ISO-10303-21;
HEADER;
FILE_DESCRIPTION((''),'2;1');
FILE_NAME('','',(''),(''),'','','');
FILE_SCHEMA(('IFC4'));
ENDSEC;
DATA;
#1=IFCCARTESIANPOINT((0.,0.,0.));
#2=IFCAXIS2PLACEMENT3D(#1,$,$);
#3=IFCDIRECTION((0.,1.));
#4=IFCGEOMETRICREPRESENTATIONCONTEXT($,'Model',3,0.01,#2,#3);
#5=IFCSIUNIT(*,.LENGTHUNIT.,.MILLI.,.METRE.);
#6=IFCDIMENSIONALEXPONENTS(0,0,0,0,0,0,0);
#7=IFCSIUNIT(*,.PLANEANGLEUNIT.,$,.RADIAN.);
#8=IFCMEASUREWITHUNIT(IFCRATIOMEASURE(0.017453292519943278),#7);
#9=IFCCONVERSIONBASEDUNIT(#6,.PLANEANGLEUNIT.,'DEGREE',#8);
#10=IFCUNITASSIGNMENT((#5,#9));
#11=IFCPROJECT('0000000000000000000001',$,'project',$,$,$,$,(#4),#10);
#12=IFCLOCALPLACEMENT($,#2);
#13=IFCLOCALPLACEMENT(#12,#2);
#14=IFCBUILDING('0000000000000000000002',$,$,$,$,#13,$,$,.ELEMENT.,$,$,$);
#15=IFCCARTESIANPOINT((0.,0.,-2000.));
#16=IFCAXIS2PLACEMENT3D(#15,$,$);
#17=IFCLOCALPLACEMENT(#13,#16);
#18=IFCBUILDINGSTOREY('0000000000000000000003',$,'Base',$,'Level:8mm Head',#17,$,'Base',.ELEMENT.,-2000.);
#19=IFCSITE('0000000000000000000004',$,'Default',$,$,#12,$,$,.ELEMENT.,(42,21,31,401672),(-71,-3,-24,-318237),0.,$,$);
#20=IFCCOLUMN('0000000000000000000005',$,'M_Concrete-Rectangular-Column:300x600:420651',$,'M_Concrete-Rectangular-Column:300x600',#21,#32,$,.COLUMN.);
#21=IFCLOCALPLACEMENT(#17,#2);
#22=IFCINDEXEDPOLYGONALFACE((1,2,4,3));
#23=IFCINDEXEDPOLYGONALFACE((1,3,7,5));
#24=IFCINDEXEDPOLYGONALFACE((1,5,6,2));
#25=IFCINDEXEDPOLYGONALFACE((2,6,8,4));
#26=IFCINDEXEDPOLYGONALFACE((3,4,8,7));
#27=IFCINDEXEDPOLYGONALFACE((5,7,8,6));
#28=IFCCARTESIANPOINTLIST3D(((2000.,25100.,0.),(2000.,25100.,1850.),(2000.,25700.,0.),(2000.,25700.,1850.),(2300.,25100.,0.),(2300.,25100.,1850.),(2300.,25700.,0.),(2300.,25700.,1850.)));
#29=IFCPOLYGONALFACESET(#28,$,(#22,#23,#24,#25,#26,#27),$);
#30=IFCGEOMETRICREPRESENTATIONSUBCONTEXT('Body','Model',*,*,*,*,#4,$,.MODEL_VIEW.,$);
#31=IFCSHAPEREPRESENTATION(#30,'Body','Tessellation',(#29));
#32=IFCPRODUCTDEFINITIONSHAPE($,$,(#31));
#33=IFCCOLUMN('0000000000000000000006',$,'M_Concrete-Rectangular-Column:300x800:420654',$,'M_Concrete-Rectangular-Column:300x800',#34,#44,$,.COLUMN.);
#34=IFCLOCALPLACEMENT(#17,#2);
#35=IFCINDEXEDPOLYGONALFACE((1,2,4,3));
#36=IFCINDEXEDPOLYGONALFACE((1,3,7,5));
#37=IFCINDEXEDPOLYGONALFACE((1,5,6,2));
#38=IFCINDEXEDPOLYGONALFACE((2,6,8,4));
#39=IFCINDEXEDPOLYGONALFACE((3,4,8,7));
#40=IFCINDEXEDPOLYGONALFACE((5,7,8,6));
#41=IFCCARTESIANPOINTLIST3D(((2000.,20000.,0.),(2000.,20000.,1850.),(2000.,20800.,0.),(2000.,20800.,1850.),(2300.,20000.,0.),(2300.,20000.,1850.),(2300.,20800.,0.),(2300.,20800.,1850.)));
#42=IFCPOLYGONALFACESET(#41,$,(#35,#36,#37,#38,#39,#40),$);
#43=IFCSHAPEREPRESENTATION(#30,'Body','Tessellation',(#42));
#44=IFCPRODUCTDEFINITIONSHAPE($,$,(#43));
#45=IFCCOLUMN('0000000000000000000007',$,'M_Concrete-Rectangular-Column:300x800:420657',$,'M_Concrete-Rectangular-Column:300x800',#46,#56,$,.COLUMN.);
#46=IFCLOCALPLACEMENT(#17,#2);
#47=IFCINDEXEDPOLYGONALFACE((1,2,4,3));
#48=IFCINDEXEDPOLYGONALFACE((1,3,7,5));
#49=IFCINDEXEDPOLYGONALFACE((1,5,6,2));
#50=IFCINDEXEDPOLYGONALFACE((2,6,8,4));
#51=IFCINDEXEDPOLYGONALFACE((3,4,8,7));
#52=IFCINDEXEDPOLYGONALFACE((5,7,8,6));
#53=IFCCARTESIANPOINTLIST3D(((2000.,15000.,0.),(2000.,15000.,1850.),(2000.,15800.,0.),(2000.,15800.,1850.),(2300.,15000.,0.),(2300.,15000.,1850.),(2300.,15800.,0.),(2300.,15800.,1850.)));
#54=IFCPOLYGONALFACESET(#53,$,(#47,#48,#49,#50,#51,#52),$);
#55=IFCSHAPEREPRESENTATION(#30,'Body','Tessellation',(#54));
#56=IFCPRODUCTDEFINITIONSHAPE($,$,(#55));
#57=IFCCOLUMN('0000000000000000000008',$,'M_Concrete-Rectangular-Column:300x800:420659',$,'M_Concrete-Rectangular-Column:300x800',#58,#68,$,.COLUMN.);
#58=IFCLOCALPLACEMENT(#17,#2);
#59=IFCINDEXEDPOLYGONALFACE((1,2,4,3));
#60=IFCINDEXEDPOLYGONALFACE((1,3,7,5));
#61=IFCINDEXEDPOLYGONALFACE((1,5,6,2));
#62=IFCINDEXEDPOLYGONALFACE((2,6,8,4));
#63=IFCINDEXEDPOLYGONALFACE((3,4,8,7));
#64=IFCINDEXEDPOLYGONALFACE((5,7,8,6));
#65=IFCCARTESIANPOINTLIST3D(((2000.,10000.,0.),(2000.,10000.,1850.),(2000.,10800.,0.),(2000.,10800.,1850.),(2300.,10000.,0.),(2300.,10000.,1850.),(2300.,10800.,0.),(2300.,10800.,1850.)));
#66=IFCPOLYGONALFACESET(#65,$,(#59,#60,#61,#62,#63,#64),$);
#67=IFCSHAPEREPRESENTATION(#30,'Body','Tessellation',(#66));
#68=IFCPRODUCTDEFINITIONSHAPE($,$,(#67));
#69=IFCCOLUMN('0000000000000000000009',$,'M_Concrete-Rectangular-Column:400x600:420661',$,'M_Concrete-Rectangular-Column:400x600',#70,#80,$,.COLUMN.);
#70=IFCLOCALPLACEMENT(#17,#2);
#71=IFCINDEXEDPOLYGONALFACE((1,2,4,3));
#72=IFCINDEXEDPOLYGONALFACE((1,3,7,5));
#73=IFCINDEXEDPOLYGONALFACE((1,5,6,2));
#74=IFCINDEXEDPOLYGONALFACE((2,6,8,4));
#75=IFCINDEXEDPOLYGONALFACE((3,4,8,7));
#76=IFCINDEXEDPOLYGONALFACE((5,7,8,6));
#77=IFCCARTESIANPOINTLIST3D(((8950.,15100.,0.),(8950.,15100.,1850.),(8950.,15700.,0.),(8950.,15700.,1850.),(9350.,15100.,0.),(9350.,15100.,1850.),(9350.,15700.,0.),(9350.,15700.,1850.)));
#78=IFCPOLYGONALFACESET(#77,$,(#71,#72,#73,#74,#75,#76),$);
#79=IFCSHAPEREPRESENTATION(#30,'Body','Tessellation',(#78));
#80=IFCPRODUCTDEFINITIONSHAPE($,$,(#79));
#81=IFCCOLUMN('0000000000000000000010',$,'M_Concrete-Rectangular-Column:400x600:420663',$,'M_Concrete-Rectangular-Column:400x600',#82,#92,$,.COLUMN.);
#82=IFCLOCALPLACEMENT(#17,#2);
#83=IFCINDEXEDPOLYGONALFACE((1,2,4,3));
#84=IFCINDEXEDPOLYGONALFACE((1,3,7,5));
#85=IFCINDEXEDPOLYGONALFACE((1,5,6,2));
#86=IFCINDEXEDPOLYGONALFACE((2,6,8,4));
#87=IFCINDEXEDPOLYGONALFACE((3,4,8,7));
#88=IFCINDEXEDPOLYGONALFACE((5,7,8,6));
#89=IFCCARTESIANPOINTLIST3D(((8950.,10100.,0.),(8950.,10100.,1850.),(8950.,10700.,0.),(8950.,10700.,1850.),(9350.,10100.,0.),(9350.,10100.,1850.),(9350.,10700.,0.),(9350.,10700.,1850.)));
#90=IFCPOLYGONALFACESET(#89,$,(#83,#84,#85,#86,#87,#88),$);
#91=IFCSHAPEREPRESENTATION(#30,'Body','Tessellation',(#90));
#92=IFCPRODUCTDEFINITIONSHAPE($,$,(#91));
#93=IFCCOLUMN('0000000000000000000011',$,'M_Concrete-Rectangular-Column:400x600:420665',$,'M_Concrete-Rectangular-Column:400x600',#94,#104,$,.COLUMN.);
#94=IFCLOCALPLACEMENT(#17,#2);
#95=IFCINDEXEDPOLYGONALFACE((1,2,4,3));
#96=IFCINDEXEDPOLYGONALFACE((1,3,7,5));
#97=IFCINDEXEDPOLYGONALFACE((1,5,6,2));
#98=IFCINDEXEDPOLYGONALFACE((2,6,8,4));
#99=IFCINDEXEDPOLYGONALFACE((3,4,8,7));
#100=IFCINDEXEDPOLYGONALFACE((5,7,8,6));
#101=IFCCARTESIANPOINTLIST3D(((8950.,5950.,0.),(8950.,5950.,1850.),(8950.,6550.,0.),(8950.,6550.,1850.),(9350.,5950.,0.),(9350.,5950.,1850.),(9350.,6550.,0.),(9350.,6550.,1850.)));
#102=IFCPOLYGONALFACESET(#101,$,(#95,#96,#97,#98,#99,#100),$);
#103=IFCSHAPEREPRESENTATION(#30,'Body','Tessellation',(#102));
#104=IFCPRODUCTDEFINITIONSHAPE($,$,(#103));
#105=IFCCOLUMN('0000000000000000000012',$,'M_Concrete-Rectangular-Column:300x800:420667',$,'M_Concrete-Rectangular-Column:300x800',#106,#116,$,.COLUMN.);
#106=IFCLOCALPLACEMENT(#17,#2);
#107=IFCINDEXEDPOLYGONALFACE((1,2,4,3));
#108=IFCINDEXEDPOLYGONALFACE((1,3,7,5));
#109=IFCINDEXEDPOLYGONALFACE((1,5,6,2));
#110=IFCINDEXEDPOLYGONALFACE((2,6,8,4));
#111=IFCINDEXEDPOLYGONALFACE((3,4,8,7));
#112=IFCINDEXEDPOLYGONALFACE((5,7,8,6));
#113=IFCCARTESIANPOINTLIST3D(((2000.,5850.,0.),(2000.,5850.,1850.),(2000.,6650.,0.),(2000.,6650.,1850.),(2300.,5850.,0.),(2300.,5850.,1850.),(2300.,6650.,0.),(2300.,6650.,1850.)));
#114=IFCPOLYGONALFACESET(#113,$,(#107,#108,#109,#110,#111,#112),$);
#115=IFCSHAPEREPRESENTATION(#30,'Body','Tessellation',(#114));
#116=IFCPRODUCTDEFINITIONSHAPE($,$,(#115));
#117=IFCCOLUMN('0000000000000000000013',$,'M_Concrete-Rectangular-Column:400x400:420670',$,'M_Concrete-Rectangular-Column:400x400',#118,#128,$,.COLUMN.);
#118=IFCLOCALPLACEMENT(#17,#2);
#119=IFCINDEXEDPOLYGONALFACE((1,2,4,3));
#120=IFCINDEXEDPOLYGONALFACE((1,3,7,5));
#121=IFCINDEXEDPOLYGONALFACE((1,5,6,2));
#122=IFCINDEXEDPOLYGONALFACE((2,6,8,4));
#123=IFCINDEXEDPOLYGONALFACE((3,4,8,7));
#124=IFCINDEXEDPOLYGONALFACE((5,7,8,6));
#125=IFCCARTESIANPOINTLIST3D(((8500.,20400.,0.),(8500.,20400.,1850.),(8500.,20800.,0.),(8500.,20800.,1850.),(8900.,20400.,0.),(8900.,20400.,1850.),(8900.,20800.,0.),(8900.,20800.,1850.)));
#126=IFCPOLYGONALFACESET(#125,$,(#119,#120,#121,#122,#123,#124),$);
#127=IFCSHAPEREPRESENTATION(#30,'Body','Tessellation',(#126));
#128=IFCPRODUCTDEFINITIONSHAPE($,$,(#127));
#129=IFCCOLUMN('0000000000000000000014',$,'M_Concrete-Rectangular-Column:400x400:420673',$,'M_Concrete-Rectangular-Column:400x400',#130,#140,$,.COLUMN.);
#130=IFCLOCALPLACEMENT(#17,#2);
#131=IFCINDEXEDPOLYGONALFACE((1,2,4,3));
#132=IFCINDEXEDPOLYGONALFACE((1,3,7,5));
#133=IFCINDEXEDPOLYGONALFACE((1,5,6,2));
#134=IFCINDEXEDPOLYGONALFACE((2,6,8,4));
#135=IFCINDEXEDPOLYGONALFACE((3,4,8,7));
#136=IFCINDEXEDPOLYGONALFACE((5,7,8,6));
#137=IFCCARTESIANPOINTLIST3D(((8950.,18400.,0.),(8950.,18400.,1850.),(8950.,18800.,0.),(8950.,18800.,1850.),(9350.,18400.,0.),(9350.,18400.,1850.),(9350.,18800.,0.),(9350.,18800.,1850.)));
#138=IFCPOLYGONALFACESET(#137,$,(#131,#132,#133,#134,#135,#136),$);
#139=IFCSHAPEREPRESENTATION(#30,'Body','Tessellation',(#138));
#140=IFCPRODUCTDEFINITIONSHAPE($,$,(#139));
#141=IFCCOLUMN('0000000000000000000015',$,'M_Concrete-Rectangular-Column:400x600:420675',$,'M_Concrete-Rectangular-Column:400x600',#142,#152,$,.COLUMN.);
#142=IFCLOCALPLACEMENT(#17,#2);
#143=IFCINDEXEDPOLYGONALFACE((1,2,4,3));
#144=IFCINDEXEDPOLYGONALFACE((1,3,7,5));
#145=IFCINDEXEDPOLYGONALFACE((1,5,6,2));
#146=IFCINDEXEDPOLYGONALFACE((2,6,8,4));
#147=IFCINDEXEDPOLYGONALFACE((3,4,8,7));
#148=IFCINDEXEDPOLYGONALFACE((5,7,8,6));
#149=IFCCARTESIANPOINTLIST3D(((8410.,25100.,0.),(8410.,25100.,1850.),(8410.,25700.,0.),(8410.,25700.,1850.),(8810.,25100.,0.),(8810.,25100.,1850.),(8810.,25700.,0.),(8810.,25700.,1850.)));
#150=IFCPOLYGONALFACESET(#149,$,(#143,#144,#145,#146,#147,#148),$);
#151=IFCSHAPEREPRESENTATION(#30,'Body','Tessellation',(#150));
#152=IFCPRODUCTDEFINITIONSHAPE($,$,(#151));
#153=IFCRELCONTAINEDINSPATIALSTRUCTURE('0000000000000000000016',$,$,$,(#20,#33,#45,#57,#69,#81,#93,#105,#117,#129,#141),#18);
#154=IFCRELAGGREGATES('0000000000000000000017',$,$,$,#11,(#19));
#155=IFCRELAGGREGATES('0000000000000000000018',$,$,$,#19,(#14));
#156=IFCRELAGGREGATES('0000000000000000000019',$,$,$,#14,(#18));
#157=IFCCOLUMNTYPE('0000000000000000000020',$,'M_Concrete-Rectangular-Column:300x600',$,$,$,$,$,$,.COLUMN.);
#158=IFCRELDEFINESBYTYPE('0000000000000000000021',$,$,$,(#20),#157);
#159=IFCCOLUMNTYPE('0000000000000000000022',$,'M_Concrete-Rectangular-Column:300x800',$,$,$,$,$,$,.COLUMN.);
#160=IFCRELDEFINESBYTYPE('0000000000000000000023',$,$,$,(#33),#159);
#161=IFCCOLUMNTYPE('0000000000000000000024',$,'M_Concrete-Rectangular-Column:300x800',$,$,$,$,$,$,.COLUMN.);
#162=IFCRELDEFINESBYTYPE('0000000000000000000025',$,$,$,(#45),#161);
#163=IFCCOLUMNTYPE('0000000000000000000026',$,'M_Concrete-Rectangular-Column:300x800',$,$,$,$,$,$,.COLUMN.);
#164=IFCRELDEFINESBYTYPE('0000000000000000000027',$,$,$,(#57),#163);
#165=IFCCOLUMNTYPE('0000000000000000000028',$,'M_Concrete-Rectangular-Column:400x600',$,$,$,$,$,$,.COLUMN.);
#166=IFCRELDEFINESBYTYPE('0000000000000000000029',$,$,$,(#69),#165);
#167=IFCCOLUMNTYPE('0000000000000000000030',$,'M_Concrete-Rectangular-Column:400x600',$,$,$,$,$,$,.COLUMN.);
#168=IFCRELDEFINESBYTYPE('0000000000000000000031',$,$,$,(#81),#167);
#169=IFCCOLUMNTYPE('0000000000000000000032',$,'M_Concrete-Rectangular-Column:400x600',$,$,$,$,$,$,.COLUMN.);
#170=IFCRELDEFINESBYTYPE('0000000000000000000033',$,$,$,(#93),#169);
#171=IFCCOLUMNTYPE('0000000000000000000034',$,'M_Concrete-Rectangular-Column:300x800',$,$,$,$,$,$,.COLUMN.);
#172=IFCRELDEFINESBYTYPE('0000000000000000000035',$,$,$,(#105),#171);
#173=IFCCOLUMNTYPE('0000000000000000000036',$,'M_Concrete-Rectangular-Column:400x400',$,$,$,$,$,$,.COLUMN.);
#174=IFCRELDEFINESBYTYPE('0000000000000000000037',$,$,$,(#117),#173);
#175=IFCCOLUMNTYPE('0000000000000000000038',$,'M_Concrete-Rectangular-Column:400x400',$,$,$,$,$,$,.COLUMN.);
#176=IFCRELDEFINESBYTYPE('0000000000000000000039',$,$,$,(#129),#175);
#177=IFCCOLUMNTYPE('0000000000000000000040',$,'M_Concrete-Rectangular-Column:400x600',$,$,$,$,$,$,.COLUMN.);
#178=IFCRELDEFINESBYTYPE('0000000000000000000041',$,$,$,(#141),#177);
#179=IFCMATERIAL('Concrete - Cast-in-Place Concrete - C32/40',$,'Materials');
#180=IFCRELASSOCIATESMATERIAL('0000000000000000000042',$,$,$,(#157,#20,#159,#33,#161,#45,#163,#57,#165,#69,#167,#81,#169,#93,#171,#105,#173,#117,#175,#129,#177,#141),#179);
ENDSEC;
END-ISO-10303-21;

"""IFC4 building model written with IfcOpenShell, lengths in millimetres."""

from ifc_helpers import new_model, entity, si_unit, converted_unit, direction, frame, origin, place, context, subcontext, project, spatial, indexed_curve, outline, extrude, source, transform, mapped, material, type_object, type_shapes, element, save


model = new_model("IFC4")

# Units and contexts
model_context = context("Model", 3, precision=0.01, world=origin(), true_north=direction((0.0, 1.0)))
body_context = subcontext(model_context, "Body", "Model", "MODEL_VIEW")
ifc_project = project(units=[si_unit("LENGTHUNIT", "METRE", prefix="MILLI"), converted_unit("PLANEANGLEUNIT", "DEGREE", entity("IfcRatioMeasure", 0.017453292519943278), si_unit("PLANEANGLEUNIT", "RADIAN"), dimensions=[0, 0, 0, 0, 0, 0, 0])], contexts=[model_context])

# Site, building, storey
site_placement = place(None, origin())
site = spatial("IfcSite", under=ifc_project, at=site_placement, Name="Default", CompositionType="ELEMENT", RefLatitude=(42, 21, 31, 401672), RefLongitude=(-71, -3, -24, -318237), RefElevation=0.0)
building_placement = place(site_placement, origin())
building = spatial("IfcBuilding", under=site, at=building_placement, CompositionType="ELEMENT")
storey_placement = place(building_placement, frame((0.0, 0.0, -2000.0)))
storey = spatial("IfcBuildingStorey", under=building, at=storey_placement, Name="Base", ObjectType="Level:8mm Head", LongName="Base", CompositionType="ELEMENT", Elevation=-2000.0)

# Columns
ifc_material = material(Name="Concrete - Cast-in-Place Concrete - C32/40", Category="Materials")
column_type_1 = type_object("IfcColumnType", Name="M_Concrete-Rectangular-Column:300x600", PredefinedType="COLUMN", material=ifc_material)
shared_shape_1 = source(origin(), body_context, "Body", "SweptSolid", [
    extrude(outline(indexed_curve([(-300.0, -150.0), (300.0, -150.0), (300.0, 150.0), (-300.0, 150.0), (-300.0, -150.0)], self_intersect=False)), frame((2150.0, 25400.0, -2000.0), z_axis=(0.0, 0.0, 1.0), x_axis=(0.0, -1.0, 0.0)), (0.0, 0.0, 1.0), 1850.0),
])
type_shapes(column_type_1, [shared_shape_1])
column_1_placement = place(storey_placement, frame((0.0, 0.0, 2000.0)))
element("IfcColumn", 1, at=column_1_placement, inside=storey, type_object=column_type_1, material=ifc_material, Name="M_Concrete-Rectangular-Column:300x600:420651", ObjectType="M_Concrete-Rectangular-Column:300x600", PredefinedType="COLUMN", context=body_context, shape_type="MappedRepresentation", body=[
    mapped(shared_shape_1, transform((0.0, 0.0, 0.0), scale=1.0)),
])
column_type_2 = type_object("IfcColumnType", Name="M_Concrete-Rectangular-Column:300x800", PredefinedType="COLUMN", material=ifc_material)
shared_shape_2 = source(origin(), body_context, "Body", "SweptSolid", [
    extrude(outline(indexed_curve([(-400.0, -150.0), (400.0, -150.0), (400.0, 150.0), (-400.0, 150.0), (-400.0, -150.0)], self_intersect=False)), frame((2150.0, 20400.0, -2000.0), z_axis=(0.0, 0.0, 1.0), x_axis=(0.0, -1.0, 0.0)), (0.0, 0.0, 1.0), 1850.0),
])
type_shapes(column_type_2, [shared_shape_2])
column_2_placement = place(storey_placement, frame((0.0, 0.0, 2000.0)))
element("IfcColumn", 2, at=column_2_placement, inside=storey, type_object=column_type_2, material=ifc_material, Name="M_Concrete-Rectangular-Column:300x800:420654", ObjectType="M_Concrete-Rectangular-Column:300x800", PredefinedType="COLUMN", context=body_context, shape_type="MappedRepresentation", body=[
    mapped(shared_shape_2, transform((0.0, 0.0, 0.0), scale=1.0)),
])
column_type_3 = type_object("IfcColumnType", Name="M_Concrete-Rectangular-Column:300x800", PredefinedType="COLUMN", material=ifc_material)
shared_shape_3 = source(origin(), body_context, "Body", "SweptSolid", [
    extrude(outline(indexed_curve([(-400.0, -150.0), (400.0, -150.0), (400.0, 150.0), (-400.0, 150.0), (-400.0, -150.0)], self_intersect=False)), frame((2150.0, 15400.0, -2000.0), z_axis=(0.0, 0.0, 1.0), x_axis=(0.0, -1.0, 0.0)), (0.0, 0.0, 1.0), 1850.0),
])
type_shapes(column_type_3, [shared_shape_3])
column_3_placement = place(storey_placement, frame((0.0, 0.0, 2000.0)))
element("IfcColumn", 3, at=column_3_placement, inside=storey, type_object=column_type_3, material=ifc_material, Name="M_Concrete-Rectangular-Column:300x800:420657", ObjectType="M_Concrete-Rectangular-Column:300x800", PredefinedType="COLUMN", context=body_context, shape_type="MappedRepresentation", body=[
    mapped(shared_shape_3, transform((0.0, 0.0, 0.0), scale=1.0)),
])
column_type_4 = type_object("IfcColumnType", Name="M_Concrete-Rectangular-Column:300x800", PredefinedType="COLUMN", material=ifc_material)
shared_shape_4 = source(origin(), body_context, "Body", "SweptSolid", [
    extrude(outline(indexed_curve([(-400.0, -150.0), (400.0, -150.0), (400.0, 150.0), (-400.0, 150.0), (-400.0, -150.0)], self_intersect=False)), frame((2150.0, 10400.0, -2000.0), z_axis=(0.0, 0.0, 1.0), x_axis=(0.0, -1.0, 0.0)), (0.0, 0.0, 1.0), 1850.0),
])
type_shapes(column_type_4, [shared_shape_4])
column_4_placement = place(storey_placement, frame((0.0, 0.0, 2000.0)))
element("IfcColumn", 4, at=column_4_placement, inside=storey, type_object=column_type_4, material=ifc_material, Name="M_Concrete-Rectangular-Column:300x800:420659", ObjectType="M_Concrete-Rectangular-Column:300x800", PredefinedType="COLUMN", context=body_context, shape_type="MappedRepresentation", body=[
    mapped(shared_shape_4, transform((0.0, 0.0, 0.0), scale=1.0)),
])
column_type_5 = type_object("IfcColumnType", Name="M_Concrete-Rectangular-Column:400x600", PredefinedType="COLUMN", material=ifc_material)
shared_shape_5 = source(origin(), body_context, "Body", "SweptSolid", [
    extrude(outline(indexed_curve([(-300.0, -200.0), (300.0, -200.0), (300.0, 200.0), (-300.0, 200.0), (-300.0, -200.0)], self_intersect=False)), frame((9150.0, 15400.0, -2000.0), z_axis=(0.0, 0.0, 1.0), x_axis=(0.0, -1.0, 0.0)), (0.0, 0.0, 1.0), 1850.0),
])
type_shapes(column_type_5, [shared_shape_5])
column_5_placement = place(storey_placement, frame((0.0, 0.0, 2000.0)))
element("IfcColumn", 5, at=column_5_placement, inside=storey, type_object=column_type_5, material=ifc_material, Name="M_Concrete-Rectangular-Column:400x600:420661", ObjectType="M_Concrete-Rectangular-Column:400x600", PredefinedType="COLUMN", context=body_context, shape_type="MappedRepresentation", body=[
    mapped(shared_shape_5, transform((0.0, 0.0, 0.0), scale=1.0)),
])
column_type_6 = type_object("IfcColumnType", Name="M_Concrete-Rectangular-Column:400x600", PredefinedType="COLUMN", material=ifc_material)
shared_shape_6 = source(origin(), body_context, "Body", "SweptSolid", [
    extrude(outline(indexed_curve([(-300.0, -200.0), (300.0, -200.0), (300.0, 200.0), (-300.0, 200.0), (-300.0, -200.0)], self_intersect=False)), frame((9150.0, 10400.0, -2000.0), z_axis=(0.0, 0.0, 1.0), x_axis=(0.0, -1.0, 0.0)), (0.0, 0.0, 1.0), 1850.0),
])
type_shapes(column_type_6, [shared_shape_6])
column_6_placement = place(storey_placement, frame((0.0, 0.0, 2000.0)))
element("IfcColumn", 6, at=column_6_placement, inside=storey, type_object=column_type_6, material=ifc_material, Name="M_Concrete-Rectangular-Column:400x600:420663", ObjectType="M_Concrete-Rectangular-Column:400x600", PredefinedType="COLUMN", context=body_context, shape_type="MappedRepresentation", body=[
    mapped(shared_shape_6, transform((0.0, 0.0, 0.0), scale=1.0)),
])
column_type_7 = type_object("IfcColumnType", Name="M_Concrete-Rectangular-Column:400x600", PredefinedType="COLUMN", material=ifc_material)
shared_shape_7 = source(origin(), body_context, "Body", "SweptSolid", [
    extrude(outline(indexed_curve([(-300.0, -200.0), (300.0, -200.0), (300.0, 200.0), (-300.0, 200.0), (-300.0, -200.0)], self_intersect=False)), frame((9150.0, 6250.0, -2000.0), z_axis=(0.0, 0.0, 1.0), x_axis=(0.0, -1.0, 0.0)), (0.0, 0.0, 1.0), 1850.0),
])
type_shapes(column_type_7, [shared_shape_7])
column_7_placement = place(storey_placement, frame((0.0, 0.0, 2000.0)))
element("IfcColumn", 7, at=column_7_placement, inside=storey, type_object=column_type_7, material=ifc_material, Name="M_Concrete-Rectangular-Column:400x600:420665", ObjectType="M_Concrete-Rectangular-Column:400x600", PredefinedType="COLUMN", context=body_context, shape_type="MappedRepresentation", body=[
    mapped(shared_shape_7, transform((0.0, 0.0, 0.0), scale=1.0)),
])
column_type_8 = type_object("IfcColumnType", Name="M_Concrete-Rectangular-Column:300x800", PredefinedType="COLUMN", material=ifc_material)
shared_shape_8 = source(origin(), body_context, "Body", "SweptSolid", [
    extrude(outline(indexed_curve([(-400.0, -150.0), (400.0, -150.0), (400.0, 150.0), (-400.0, 150.0), (-400.0, -150.0)], self_intersect=False)), frame((2150.0, 6250.0, -2000.0), z_axis=(0.0, 0.0, 1.0), x_axis=(0.0, -1.0, 0.0)), (0.0, 0.0, 1.0), 1850.0),
])
type_shapes(column_type_8, [shared_shape_8])
column_8_placement = place(storey_placement, frame((0.0, 0.0, 2000.0)))
element("IfcColumn", 8, at=column_8_placement, inside=storey, type_object=column_type_8, material=ifc_material, Name="M_Concrete-Rectangular-Column:300x800:420667", ObjectType="M_Concrete-Rectangular-Column:300x800", PredefinedType="COLUMN", context=body_context, shape_type="MappedRepresentation", body=[
    mapped(shared_shape_8, transform((0.0, 0.0, 0.0), scale=1.0)),
])
column_type_9 = type_object("IfcColumnType", Name="M_Concrete-Rectangular-Column:400x400", PredefinedType="COLUMN", material=ifc_material)
shared_shape_9 = source(origin(), body_context, "Body", "SweptSolid", [
    extrude(outline(indexed_curve([(-200.0, -200.0), (200.0, -200.0), (200.0, 200.0), (-200.0, 200.0), (-200.0, -200.0)], self_intersect=False)), frame((8700.0, 20600.0, -2000.0), z_axis=(0.0, 0.0, 1.0), x_axis=(0.0, -1.0, 0.0)), (0.0, 0.0, 1.0), 1850.0),
])
type_shapes(column_type_9, [shared_shape_9])
column_9_placement = place(storey_placement, frame((0.0, 0.0, 2000.0)))
element("IfcColumn", 9, at=column_9_placement, inside=storey, type_object=column_type_9, material=ifc_material, Name="M_Concrete-Rectangular-Column:400x400:420670", ObjectType="M_Concrete-Rectangular-Column:400x400", PredefinedType="COLUMN", context=body_context, shape_type="MappedRepresentation", body=[
    mapped(shared_shape_9, transform((0.0, 0.0, 0.0), scale=1.0)),
])
column_type_10 = type_object("IfcColumnType", Name="M_Concrete-Rectangular-Column:400x400", PredefinedType="COLUMN", material=ifc_material)
shared_shape_10 = source(origin(), body_context, "Body", "SweptSolid", [
    extrude(outline(indexed_curve([(-200.0, -200.0), (200.0, -200.0), (200.0, 200.0), (-200.0, 200.0), (-200.0, -200.0)], self_intersect=False)), frame((9150.0, 18600.0, -2000.0), z_axis=(0.0, 0.0, 1.0), x_axis=(0.0, -1.0, 0.0)), (0.0, 0.0, 1.0), 1850.0),
])
type_shapes(column_type_10, [shared_shape_10])
column_10_placement = place(storey_placement, frame((0.0, 0.0, 2000.0)))
element("IfcColumn", 10, at=column_10_placement, inside=storey, type_object=column_type_10, material=ifc_material, Name="M_Concrete-Rectangular-Column:400x400:420673", ObjectType="M_Concrete-Rectangular-Column:400x400", PredefinedType="COLUMN", context=body_context, shape_type="MappedRepresentation", body=[
    mapped(shared_shape_10, transform((0.0, 0.0, 0.0), scale=1.0)),
])
column_type_11 = type_object("IfcColumnType", Name="M_Concrete-Rectangular-Column:400x600", PredefinedType="COLUMN", material=ifc_material)
shared_shape_11 = source(origin(), body_context, "Body", "SweptSolid", [
    extrude(outline(indexed_curve([(-300.0, -200.0), (300.0, -200.0), (300.0, 200.0), (-300.0, 200.0), (-300.0, -200.0)], self_intersect=False)), frame((8610.0, 25400.0, -2000.0), z_axis=(0.0, 0.0, 1.0), x_axis=(0.0, -1.0, 0.0)), (0.0, 0.0, 1.0), 1850.0),
])
type_shapes(column_type_11, [shared_shape_11])
column_11_placement = place(storey_placement, frame((0.0, 0.0, 2000.0)))
element("IfcColumn", 11, at=column_11_placement, inside=storey, type_object=column_type_11, material=ifc_material, Name="M_Concrete-Rectangular-Column:400x600:420675", ObjectType="M_Concrete-Rectangular-Column:400x600", PredefinedType="COLUMN", context=body_context, shape_type="MappedRepresentation", body=[
    mapped(shared_shape_11, transform((0.0, 0.0, 0.0), scale=1.0)),
])

save(model, "model.ifc")
